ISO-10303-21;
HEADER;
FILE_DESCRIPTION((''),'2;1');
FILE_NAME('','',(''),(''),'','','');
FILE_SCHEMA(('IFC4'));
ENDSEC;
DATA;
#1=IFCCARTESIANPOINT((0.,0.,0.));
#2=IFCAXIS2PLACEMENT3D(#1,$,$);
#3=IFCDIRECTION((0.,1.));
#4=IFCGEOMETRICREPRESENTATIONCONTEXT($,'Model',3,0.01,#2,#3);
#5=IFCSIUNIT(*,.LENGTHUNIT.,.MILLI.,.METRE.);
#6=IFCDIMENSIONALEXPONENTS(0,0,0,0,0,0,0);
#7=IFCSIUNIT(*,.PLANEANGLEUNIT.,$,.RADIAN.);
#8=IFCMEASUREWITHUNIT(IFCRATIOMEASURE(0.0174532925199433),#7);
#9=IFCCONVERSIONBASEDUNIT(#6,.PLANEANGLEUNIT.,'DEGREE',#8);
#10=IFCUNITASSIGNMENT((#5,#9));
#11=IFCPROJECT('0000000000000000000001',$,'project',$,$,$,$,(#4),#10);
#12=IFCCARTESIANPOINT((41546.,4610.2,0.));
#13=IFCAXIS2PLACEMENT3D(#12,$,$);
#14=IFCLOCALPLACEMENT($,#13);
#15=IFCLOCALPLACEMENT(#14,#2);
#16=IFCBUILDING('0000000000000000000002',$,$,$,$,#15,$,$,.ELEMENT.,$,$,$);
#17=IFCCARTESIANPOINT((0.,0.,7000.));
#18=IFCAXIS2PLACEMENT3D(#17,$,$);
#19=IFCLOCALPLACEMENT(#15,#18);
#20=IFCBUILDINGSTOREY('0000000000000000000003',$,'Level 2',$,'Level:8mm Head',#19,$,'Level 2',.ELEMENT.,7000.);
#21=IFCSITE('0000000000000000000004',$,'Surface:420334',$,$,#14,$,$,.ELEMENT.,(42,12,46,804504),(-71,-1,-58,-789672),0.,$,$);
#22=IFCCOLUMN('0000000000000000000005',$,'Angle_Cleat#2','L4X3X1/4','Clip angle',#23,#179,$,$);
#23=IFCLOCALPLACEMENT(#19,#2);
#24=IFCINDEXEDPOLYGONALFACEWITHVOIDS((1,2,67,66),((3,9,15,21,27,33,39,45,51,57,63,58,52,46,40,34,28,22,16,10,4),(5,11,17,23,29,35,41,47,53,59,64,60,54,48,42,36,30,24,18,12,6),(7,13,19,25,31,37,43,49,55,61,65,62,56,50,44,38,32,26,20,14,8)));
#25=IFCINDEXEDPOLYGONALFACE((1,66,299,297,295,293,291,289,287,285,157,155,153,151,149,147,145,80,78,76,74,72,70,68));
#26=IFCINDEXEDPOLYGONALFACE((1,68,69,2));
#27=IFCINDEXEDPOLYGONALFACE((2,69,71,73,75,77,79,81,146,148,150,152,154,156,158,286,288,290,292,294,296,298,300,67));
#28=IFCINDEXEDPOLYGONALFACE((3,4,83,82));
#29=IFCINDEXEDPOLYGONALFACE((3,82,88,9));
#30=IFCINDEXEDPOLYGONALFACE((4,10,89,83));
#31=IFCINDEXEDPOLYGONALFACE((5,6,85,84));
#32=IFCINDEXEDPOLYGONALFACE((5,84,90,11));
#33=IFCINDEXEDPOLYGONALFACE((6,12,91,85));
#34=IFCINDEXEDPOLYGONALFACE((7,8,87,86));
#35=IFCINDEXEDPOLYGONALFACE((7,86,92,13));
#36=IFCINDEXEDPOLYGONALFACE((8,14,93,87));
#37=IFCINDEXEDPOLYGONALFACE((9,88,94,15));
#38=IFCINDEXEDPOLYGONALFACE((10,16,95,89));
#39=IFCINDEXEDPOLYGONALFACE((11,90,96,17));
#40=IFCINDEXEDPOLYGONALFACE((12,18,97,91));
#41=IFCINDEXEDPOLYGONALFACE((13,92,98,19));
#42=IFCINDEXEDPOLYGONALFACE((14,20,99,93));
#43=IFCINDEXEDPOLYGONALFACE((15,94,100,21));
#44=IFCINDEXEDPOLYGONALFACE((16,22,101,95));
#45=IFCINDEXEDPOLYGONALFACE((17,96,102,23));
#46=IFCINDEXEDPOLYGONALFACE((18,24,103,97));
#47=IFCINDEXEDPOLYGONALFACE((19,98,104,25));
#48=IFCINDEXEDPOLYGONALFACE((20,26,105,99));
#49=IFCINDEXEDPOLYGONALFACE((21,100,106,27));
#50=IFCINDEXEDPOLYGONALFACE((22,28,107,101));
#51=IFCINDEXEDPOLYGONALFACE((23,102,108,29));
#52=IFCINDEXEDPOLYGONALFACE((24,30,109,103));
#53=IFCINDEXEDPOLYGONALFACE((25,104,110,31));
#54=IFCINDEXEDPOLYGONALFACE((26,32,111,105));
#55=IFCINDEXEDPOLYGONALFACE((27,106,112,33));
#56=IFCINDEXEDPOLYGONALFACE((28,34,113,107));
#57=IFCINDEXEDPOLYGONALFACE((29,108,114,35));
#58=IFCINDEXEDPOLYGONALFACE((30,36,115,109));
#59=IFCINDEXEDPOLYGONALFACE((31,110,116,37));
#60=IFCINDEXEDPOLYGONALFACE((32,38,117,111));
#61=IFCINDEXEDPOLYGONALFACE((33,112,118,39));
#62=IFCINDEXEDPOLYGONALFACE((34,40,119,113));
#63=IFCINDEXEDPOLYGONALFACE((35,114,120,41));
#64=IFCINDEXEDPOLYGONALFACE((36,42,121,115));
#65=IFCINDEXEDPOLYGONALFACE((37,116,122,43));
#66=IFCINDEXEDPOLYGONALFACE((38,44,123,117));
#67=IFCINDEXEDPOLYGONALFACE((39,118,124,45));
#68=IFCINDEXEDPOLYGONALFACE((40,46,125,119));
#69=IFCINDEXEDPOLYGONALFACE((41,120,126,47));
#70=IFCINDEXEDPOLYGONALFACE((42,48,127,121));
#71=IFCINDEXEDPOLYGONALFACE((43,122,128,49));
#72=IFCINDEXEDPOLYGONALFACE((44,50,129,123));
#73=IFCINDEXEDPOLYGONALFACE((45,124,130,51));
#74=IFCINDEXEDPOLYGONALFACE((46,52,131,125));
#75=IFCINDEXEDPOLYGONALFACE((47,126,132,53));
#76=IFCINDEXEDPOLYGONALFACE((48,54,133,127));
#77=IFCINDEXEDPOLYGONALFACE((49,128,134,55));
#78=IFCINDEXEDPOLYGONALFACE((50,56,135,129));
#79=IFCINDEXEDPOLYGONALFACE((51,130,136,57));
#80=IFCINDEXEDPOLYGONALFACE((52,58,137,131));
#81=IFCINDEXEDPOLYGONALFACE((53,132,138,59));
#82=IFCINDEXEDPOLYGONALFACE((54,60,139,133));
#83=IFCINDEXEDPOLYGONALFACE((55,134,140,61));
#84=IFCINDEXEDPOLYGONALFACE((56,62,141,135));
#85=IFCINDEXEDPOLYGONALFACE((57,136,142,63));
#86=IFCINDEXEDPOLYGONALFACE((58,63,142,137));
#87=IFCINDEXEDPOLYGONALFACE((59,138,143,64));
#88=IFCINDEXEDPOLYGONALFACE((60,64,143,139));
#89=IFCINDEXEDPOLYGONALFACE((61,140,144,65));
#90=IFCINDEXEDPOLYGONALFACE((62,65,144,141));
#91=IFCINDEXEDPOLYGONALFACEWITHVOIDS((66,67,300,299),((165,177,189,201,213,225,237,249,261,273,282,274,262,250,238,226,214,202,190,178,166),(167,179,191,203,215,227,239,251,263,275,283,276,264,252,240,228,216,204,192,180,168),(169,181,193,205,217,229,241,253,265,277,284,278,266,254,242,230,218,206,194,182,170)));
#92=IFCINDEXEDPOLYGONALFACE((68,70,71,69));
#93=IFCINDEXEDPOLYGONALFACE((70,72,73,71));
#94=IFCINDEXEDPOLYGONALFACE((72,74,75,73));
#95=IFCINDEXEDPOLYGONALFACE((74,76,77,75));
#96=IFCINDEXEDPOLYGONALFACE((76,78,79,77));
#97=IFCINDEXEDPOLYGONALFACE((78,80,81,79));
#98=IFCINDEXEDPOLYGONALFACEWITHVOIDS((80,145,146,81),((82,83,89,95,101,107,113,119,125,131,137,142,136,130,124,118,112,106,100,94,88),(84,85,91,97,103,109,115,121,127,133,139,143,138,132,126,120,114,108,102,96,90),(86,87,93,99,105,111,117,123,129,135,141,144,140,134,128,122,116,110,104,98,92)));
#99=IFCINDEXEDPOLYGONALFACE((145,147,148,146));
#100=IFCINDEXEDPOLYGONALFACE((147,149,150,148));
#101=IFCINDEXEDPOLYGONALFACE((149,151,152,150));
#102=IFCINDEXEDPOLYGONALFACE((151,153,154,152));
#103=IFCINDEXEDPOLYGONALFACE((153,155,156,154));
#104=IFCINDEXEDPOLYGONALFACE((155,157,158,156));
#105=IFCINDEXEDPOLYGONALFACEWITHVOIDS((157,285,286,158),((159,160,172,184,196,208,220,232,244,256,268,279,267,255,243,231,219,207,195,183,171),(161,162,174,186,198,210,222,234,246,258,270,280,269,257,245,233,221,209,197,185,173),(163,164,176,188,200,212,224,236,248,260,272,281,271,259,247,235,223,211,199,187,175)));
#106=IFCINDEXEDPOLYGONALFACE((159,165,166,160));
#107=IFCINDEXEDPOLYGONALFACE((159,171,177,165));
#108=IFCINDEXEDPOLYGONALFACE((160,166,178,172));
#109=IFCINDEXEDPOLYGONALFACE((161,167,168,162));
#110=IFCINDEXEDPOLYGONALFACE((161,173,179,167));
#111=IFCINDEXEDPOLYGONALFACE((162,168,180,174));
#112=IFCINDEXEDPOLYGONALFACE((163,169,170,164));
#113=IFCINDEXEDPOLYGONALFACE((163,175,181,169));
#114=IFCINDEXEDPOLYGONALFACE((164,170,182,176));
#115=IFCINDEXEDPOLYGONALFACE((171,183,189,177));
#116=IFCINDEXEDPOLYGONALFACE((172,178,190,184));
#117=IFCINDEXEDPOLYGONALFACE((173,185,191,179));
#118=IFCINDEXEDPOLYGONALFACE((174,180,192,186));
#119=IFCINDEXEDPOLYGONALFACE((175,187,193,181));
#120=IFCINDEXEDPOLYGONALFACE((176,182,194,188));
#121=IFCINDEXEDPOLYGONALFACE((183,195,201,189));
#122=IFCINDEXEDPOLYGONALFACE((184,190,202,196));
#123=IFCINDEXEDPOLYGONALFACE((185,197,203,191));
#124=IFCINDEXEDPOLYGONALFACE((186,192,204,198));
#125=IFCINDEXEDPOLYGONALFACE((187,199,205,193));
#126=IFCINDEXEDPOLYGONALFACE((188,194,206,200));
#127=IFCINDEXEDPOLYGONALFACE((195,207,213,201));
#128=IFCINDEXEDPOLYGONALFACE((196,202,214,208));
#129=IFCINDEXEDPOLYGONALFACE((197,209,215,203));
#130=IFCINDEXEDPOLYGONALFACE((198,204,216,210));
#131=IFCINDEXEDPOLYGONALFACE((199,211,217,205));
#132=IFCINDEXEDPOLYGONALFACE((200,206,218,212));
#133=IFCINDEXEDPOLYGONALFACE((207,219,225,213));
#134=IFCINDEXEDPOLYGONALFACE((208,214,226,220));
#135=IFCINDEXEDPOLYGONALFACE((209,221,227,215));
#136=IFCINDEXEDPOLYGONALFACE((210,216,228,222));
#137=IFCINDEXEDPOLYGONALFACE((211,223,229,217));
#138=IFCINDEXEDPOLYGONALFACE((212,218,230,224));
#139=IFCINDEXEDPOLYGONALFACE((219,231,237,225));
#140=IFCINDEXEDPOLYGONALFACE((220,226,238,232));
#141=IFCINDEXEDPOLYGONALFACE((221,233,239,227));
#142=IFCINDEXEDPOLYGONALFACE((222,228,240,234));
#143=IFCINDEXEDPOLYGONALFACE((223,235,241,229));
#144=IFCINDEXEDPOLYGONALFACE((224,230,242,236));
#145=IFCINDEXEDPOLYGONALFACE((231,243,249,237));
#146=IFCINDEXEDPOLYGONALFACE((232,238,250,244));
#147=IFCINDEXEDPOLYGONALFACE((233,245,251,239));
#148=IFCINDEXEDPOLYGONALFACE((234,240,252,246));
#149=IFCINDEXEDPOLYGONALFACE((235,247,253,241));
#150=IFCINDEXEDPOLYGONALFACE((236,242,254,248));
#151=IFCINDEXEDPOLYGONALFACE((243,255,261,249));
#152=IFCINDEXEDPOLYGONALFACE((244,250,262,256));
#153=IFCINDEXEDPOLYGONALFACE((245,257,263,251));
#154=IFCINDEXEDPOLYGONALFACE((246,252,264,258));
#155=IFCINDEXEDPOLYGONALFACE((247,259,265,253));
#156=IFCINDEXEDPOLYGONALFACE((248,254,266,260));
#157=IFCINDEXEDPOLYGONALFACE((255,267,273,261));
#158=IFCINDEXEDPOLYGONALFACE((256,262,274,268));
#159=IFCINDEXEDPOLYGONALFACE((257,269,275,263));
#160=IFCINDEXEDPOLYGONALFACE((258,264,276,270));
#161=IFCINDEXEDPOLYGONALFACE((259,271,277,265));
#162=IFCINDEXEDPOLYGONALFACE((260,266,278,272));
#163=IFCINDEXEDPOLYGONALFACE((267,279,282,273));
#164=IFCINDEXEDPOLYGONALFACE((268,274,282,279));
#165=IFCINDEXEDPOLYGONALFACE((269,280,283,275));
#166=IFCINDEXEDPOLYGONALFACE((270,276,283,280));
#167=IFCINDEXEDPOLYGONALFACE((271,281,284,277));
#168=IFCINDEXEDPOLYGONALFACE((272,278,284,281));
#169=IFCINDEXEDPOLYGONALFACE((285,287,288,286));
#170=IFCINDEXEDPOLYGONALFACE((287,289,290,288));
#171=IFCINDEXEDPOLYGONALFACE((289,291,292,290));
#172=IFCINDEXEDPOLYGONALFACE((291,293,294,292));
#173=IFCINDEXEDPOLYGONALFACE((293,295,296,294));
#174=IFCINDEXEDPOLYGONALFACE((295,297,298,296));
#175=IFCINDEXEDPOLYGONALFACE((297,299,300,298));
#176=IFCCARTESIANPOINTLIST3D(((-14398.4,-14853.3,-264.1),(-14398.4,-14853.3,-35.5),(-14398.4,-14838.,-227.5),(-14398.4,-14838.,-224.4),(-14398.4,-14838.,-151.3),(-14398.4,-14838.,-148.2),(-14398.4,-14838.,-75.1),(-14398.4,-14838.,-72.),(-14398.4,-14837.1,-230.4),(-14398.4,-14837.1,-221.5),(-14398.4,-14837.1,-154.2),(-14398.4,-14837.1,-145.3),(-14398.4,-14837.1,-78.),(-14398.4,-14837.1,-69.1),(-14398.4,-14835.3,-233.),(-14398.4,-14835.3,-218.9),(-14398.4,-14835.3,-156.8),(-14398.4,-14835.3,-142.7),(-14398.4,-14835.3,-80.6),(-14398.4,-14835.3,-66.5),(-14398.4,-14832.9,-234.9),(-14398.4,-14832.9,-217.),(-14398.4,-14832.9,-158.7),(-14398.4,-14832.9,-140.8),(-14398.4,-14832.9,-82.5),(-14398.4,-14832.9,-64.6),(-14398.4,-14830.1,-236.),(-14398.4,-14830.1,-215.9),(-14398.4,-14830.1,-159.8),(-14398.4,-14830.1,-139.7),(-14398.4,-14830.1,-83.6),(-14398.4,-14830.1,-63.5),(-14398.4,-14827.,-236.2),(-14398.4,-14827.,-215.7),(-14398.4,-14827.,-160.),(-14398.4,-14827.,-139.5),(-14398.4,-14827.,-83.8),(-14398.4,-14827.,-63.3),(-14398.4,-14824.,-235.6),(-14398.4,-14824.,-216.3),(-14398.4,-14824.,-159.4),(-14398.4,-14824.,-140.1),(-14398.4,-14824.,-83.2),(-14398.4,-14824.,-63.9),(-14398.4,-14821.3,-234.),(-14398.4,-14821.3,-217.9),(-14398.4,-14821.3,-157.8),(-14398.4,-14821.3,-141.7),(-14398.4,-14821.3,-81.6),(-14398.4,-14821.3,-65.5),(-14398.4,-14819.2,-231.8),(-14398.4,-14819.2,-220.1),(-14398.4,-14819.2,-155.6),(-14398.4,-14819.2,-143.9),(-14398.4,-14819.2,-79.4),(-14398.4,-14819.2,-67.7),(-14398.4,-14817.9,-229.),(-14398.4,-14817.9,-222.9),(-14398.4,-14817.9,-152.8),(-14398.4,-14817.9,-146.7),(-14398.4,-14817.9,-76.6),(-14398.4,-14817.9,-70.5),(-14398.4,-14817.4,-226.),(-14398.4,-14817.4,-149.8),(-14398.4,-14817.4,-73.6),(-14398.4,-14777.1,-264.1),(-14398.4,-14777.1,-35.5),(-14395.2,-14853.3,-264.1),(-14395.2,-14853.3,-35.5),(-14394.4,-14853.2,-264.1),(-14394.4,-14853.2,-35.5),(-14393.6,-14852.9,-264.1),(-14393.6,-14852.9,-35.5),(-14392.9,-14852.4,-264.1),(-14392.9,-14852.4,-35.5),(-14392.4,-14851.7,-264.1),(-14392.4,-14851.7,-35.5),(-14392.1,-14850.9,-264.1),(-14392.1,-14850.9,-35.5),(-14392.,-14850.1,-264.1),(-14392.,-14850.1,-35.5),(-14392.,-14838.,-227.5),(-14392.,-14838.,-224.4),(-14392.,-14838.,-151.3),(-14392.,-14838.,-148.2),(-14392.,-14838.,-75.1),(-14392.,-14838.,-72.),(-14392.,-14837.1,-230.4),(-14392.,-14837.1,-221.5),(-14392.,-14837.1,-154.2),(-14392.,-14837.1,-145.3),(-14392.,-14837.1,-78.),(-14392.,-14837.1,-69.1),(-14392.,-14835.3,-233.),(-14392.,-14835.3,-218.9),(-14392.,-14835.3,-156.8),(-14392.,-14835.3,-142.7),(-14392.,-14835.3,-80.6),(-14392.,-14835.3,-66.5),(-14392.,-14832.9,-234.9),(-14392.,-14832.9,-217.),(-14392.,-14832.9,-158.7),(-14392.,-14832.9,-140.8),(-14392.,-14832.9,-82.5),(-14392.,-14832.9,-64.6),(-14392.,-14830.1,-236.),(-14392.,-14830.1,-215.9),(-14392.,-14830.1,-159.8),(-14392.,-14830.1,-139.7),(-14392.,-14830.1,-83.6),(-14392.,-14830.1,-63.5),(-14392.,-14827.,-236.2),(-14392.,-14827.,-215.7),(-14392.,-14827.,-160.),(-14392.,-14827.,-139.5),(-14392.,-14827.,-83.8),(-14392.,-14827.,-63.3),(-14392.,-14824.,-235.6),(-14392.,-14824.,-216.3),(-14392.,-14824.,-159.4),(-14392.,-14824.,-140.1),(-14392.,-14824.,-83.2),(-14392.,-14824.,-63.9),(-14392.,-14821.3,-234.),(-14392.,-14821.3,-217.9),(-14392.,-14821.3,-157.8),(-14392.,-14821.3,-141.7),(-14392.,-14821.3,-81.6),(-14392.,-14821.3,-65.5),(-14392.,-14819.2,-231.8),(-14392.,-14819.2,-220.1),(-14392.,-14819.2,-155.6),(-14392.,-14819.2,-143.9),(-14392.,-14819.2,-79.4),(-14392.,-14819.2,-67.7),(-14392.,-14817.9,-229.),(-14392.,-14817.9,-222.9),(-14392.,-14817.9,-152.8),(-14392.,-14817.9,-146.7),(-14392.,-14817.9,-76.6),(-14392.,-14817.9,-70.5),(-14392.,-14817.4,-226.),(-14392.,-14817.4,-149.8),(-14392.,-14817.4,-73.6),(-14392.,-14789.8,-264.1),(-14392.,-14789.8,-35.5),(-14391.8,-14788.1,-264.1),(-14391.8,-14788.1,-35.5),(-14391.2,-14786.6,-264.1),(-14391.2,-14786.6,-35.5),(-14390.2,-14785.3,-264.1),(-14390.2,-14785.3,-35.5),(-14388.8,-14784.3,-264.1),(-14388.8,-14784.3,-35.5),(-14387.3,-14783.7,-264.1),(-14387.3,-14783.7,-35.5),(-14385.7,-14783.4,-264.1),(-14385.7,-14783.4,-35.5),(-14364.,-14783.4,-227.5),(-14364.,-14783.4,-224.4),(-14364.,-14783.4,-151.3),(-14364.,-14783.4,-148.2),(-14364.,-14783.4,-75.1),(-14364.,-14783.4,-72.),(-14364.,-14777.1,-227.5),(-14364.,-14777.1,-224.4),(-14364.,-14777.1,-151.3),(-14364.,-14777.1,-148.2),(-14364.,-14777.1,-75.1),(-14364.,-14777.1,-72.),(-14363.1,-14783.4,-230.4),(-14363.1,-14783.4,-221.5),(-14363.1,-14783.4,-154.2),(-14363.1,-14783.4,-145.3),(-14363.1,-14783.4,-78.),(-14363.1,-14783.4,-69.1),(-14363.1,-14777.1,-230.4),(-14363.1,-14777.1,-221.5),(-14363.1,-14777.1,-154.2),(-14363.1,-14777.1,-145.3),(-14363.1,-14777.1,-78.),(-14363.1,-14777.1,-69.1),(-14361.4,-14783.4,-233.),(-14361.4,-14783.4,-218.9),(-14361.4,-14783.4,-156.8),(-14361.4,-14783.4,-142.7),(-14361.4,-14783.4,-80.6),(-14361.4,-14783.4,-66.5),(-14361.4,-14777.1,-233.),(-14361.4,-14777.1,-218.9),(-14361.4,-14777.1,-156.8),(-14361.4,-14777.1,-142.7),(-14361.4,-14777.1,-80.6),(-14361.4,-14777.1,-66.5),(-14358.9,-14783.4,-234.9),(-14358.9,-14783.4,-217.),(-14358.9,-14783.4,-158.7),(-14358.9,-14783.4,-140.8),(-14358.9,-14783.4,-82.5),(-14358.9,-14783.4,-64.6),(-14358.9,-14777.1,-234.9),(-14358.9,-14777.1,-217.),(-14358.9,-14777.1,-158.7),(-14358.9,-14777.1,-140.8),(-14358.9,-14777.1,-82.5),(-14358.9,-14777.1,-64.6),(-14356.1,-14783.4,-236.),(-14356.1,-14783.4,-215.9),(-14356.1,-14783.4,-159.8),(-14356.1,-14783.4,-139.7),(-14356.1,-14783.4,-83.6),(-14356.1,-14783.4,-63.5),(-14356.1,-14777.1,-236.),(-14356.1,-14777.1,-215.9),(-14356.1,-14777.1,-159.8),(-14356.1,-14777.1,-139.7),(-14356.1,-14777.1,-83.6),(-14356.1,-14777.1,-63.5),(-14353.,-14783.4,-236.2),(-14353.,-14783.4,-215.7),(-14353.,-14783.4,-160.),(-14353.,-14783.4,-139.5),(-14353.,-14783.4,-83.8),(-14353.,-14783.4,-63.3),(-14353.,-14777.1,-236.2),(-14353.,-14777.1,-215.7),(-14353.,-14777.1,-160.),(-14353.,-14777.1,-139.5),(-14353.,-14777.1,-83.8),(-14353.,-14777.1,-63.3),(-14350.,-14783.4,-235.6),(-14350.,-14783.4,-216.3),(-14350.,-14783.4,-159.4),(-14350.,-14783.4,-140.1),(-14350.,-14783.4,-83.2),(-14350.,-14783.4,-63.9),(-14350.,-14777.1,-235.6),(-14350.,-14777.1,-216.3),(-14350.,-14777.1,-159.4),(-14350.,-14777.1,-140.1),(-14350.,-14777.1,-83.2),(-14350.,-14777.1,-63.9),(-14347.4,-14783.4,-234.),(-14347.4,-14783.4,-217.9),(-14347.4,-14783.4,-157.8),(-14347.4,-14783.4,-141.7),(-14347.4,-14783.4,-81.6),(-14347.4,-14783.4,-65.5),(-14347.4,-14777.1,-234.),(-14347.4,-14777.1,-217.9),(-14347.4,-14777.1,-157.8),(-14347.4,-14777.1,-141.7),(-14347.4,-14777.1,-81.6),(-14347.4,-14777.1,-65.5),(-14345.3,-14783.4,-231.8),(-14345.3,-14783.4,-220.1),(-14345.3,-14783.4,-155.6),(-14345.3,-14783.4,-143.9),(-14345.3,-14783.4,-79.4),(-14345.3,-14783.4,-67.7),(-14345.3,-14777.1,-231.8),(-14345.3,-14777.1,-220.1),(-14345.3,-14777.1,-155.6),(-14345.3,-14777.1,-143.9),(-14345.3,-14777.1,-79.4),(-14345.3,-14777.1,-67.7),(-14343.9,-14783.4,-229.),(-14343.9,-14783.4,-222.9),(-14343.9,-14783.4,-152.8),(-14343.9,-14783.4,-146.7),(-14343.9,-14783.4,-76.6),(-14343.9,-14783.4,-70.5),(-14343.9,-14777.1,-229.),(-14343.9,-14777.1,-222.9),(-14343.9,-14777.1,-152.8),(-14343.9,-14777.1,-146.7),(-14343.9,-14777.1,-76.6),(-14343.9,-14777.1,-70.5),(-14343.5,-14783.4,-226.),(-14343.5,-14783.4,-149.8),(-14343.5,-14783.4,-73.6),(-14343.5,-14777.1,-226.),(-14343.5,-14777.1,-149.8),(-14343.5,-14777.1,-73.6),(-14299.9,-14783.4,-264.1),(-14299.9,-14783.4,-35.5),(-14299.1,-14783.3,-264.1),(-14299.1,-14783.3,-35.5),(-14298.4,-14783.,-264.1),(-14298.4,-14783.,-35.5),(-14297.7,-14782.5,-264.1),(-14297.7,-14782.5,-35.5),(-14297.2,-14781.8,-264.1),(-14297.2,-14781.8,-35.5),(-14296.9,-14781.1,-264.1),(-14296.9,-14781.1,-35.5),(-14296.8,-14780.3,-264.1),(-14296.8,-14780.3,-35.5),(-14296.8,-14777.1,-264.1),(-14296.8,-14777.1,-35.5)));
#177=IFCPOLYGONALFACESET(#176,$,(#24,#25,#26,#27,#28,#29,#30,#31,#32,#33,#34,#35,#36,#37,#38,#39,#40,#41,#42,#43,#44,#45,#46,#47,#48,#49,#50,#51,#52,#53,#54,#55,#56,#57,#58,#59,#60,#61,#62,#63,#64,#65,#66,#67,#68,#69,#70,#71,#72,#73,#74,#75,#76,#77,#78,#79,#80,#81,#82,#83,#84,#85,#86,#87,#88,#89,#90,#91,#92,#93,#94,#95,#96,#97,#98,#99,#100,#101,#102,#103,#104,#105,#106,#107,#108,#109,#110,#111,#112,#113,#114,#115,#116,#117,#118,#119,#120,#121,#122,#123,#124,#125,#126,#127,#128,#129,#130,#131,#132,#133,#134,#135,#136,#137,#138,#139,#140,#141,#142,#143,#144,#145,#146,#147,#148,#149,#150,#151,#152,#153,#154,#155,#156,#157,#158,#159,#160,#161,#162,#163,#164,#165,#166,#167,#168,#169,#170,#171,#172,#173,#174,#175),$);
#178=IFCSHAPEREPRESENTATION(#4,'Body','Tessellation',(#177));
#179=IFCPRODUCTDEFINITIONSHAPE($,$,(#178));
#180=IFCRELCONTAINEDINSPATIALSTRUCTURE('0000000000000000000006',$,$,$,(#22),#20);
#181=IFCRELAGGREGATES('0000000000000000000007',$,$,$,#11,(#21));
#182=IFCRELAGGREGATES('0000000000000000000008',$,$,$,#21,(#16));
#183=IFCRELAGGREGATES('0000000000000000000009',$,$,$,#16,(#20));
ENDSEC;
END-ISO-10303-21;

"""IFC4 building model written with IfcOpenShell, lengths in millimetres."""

from ifc_helpers import new_model, entity, si_unit, converted_unit, direction, frame, frame_2d, origin, origin_2d_with_axis, place, context, project, spatial, circle, l_section, extrude, element, save


model = new_model("IFC4")

# Units and contexts
model_context = context("Model", 3, precision=0.01, world=origin(), true_north=direction((0.0, 1.0)))
ifc_project = project(units=[si_unit("LENGTHUNIT", "METRE", prefix="MILLI"), converted_unit("PLANEANGLEUNIT", "DEGREE", entity("IfcRatioMeasure", 0.0174532925199433), si_unit("PLANEANGLEUNIT", "RADIAN"), dimensions=[0, 0, 0, 0, 0, 0, 0])], contexts=[model_context])

# Site, building, storey
site_placement = place(None, frame((41546.0, 4610.2, 0.0)))
site = spatial("IfcSite", under=ifc_project, at=site_placement, Name="Surface:420334", CompositionType="ELEMENT", RefLatitude=(42, 12, 46, 804504), RefLongitude=(-71, -1, -58, -789672), RefElevation=0.0)
building_placement = place(site_placement, origin())
building = spatial("IfcBuilding", under=site, at=building_placement, CompositionType="ELEMENT")
storey_placement = place(building_placement, frame((0.0, 0.0, 7000.0)))
storey = spatial("IfcBuildingStorey", under=building, at=storey_placement, Name="Level 2", ObjectType="Level:8mm Head", LongName="Level 2", CompositionType="ELEMENT", Elevation=7000.0)

# Column, openings
column_1_placement = place(storey_placement, frame((-14367.2, -14795.4, -35.5), z_axis=(0.0, 0.0, 1.0), x_axis=(0.0, -1.0, 0.0)))
column_1 = element("IfcColumn", 1, at=column_1_placement, inside=storey, Name="Angle_Cleat#2", Description="L4X3X1/4", ObjectType="Clip angle", context=model_context, shape_type="SweptSolid", body=[
    extrude(l_section(Depth=101.6, Width=76.2, Thickness=6.3, FilletRadius=6.3, EdgeRadius=3.2, at=frame_2d((19.8, 19.7))), origin(), (0.0, 0.0, -1.0), 228.6),
])
opening_1_placement = place(column_1_placement, frame((32.4, -31.5, -114.3), z_axis=(0.0, 1.0, 0.0), x_axis=(-1.0, 0.0, 0.0)))
element("IfcOpeningElement", 2, at=opening_1_placement, cuts=column_1, ObjectType="Opening", context=model_context, shape_type="SweptSolid", body=[
    extrude(circle(Radius=10.3, at=origin_2d_with_axis()), origin(), (0.0, 0.0, 1.0), 7.3),
])
opening_2_placement = place(column_1_placement, frame((32.4, -31.5, -114.3), z_axis=(0.0, 1.0, 0.0), x_axis=(-1.0, 0.0, 0.0)))
element("IfcOpeningElement", 3, at=opening_2_placement, cuts=column_1, ObjectType="Opening", context=model_context, shape_type="SweptSolid", body=[
    extrude(circle(Radius=10.3, at=frame_2d((0.0, 76.2), x_axis=(1.0, 0.0))), origin(), (0.0, 0.0, 1.0), 7.3),
])
opening_3_placement = place(column_1_placement, frame((32.4, -31.5, -114.3), z_axis=(0.0, 1.0, 0.0), x_axis=(-1.0, 0.0, 0.0)))
element("IfcOpeningElement", 4, at=opening_3_placement, cuts=column_1, ObjectType="Opening", context=model_context, shape_type="SweptSolid", body=[
    extrude(circle(Radius=10.3, at=frame_2d((0.0, -76.2), x_axis=(1.0, 0.0))), origin(), (0.0, 0.0, 1.0), 7.3),
])
opening_4_placement = place(column_1_placement, frame((-11.6, 13.5, -114.3), z_axis=(-1.0, 0.0, 0.0), x_axis=(0.0, 1.0, 0.0)))
element("IfcOpeningElement", 5, at=opening_4_placement, cuts=column_1, ObjectType="Opening", context=model_context, shape_type="SweptSolid", body=[
    extrude(circle(Radius=10.3, at=origin_2d_with_axis()), origin(), (0.0, 0.0, 1.0), 7.3),
])
opening_5_placement = place(column_1_placement, frame((-11.6, 13.5, -114.3), z_axis=(-1.0, 0.0, 0.0), x_axis=(0.0, 1.0, 0.0)))
element("IfcOpeningElement", 6, at=opening_5_placement, cuts=column_1, ObjectType="Opening", context=model_context, shape_type="SweptSolid", body=[
    extrude(circle(Radius=10.3, at=frame_2d((0.0, 76.2), x_axis=(1.0, 0.0))), origin(), (0.0, 0.0, 1.0), 7.3),
])
opening_6_placement = place(column_1_placement, frame((-11.6, 13.5, -114.3), z_axis=(-1.0, 0.0, 0.0), x_axis=(0.0, 1.0, 0.0)))
element("IfcOpeningElement", 7, at=opening_6_placement, cuts=column_1, ObjectType="Opening", context=model_context, shape_type="SweptSolid", body=[
    extrude(circle(Radius=10.3, at=frame_2d((0.0, -76.2), x_axis=(1.0, 0.0))), origin(), (0.0, 0.0, 1.0), 7.3),
])

save(model, "model.ifc")
